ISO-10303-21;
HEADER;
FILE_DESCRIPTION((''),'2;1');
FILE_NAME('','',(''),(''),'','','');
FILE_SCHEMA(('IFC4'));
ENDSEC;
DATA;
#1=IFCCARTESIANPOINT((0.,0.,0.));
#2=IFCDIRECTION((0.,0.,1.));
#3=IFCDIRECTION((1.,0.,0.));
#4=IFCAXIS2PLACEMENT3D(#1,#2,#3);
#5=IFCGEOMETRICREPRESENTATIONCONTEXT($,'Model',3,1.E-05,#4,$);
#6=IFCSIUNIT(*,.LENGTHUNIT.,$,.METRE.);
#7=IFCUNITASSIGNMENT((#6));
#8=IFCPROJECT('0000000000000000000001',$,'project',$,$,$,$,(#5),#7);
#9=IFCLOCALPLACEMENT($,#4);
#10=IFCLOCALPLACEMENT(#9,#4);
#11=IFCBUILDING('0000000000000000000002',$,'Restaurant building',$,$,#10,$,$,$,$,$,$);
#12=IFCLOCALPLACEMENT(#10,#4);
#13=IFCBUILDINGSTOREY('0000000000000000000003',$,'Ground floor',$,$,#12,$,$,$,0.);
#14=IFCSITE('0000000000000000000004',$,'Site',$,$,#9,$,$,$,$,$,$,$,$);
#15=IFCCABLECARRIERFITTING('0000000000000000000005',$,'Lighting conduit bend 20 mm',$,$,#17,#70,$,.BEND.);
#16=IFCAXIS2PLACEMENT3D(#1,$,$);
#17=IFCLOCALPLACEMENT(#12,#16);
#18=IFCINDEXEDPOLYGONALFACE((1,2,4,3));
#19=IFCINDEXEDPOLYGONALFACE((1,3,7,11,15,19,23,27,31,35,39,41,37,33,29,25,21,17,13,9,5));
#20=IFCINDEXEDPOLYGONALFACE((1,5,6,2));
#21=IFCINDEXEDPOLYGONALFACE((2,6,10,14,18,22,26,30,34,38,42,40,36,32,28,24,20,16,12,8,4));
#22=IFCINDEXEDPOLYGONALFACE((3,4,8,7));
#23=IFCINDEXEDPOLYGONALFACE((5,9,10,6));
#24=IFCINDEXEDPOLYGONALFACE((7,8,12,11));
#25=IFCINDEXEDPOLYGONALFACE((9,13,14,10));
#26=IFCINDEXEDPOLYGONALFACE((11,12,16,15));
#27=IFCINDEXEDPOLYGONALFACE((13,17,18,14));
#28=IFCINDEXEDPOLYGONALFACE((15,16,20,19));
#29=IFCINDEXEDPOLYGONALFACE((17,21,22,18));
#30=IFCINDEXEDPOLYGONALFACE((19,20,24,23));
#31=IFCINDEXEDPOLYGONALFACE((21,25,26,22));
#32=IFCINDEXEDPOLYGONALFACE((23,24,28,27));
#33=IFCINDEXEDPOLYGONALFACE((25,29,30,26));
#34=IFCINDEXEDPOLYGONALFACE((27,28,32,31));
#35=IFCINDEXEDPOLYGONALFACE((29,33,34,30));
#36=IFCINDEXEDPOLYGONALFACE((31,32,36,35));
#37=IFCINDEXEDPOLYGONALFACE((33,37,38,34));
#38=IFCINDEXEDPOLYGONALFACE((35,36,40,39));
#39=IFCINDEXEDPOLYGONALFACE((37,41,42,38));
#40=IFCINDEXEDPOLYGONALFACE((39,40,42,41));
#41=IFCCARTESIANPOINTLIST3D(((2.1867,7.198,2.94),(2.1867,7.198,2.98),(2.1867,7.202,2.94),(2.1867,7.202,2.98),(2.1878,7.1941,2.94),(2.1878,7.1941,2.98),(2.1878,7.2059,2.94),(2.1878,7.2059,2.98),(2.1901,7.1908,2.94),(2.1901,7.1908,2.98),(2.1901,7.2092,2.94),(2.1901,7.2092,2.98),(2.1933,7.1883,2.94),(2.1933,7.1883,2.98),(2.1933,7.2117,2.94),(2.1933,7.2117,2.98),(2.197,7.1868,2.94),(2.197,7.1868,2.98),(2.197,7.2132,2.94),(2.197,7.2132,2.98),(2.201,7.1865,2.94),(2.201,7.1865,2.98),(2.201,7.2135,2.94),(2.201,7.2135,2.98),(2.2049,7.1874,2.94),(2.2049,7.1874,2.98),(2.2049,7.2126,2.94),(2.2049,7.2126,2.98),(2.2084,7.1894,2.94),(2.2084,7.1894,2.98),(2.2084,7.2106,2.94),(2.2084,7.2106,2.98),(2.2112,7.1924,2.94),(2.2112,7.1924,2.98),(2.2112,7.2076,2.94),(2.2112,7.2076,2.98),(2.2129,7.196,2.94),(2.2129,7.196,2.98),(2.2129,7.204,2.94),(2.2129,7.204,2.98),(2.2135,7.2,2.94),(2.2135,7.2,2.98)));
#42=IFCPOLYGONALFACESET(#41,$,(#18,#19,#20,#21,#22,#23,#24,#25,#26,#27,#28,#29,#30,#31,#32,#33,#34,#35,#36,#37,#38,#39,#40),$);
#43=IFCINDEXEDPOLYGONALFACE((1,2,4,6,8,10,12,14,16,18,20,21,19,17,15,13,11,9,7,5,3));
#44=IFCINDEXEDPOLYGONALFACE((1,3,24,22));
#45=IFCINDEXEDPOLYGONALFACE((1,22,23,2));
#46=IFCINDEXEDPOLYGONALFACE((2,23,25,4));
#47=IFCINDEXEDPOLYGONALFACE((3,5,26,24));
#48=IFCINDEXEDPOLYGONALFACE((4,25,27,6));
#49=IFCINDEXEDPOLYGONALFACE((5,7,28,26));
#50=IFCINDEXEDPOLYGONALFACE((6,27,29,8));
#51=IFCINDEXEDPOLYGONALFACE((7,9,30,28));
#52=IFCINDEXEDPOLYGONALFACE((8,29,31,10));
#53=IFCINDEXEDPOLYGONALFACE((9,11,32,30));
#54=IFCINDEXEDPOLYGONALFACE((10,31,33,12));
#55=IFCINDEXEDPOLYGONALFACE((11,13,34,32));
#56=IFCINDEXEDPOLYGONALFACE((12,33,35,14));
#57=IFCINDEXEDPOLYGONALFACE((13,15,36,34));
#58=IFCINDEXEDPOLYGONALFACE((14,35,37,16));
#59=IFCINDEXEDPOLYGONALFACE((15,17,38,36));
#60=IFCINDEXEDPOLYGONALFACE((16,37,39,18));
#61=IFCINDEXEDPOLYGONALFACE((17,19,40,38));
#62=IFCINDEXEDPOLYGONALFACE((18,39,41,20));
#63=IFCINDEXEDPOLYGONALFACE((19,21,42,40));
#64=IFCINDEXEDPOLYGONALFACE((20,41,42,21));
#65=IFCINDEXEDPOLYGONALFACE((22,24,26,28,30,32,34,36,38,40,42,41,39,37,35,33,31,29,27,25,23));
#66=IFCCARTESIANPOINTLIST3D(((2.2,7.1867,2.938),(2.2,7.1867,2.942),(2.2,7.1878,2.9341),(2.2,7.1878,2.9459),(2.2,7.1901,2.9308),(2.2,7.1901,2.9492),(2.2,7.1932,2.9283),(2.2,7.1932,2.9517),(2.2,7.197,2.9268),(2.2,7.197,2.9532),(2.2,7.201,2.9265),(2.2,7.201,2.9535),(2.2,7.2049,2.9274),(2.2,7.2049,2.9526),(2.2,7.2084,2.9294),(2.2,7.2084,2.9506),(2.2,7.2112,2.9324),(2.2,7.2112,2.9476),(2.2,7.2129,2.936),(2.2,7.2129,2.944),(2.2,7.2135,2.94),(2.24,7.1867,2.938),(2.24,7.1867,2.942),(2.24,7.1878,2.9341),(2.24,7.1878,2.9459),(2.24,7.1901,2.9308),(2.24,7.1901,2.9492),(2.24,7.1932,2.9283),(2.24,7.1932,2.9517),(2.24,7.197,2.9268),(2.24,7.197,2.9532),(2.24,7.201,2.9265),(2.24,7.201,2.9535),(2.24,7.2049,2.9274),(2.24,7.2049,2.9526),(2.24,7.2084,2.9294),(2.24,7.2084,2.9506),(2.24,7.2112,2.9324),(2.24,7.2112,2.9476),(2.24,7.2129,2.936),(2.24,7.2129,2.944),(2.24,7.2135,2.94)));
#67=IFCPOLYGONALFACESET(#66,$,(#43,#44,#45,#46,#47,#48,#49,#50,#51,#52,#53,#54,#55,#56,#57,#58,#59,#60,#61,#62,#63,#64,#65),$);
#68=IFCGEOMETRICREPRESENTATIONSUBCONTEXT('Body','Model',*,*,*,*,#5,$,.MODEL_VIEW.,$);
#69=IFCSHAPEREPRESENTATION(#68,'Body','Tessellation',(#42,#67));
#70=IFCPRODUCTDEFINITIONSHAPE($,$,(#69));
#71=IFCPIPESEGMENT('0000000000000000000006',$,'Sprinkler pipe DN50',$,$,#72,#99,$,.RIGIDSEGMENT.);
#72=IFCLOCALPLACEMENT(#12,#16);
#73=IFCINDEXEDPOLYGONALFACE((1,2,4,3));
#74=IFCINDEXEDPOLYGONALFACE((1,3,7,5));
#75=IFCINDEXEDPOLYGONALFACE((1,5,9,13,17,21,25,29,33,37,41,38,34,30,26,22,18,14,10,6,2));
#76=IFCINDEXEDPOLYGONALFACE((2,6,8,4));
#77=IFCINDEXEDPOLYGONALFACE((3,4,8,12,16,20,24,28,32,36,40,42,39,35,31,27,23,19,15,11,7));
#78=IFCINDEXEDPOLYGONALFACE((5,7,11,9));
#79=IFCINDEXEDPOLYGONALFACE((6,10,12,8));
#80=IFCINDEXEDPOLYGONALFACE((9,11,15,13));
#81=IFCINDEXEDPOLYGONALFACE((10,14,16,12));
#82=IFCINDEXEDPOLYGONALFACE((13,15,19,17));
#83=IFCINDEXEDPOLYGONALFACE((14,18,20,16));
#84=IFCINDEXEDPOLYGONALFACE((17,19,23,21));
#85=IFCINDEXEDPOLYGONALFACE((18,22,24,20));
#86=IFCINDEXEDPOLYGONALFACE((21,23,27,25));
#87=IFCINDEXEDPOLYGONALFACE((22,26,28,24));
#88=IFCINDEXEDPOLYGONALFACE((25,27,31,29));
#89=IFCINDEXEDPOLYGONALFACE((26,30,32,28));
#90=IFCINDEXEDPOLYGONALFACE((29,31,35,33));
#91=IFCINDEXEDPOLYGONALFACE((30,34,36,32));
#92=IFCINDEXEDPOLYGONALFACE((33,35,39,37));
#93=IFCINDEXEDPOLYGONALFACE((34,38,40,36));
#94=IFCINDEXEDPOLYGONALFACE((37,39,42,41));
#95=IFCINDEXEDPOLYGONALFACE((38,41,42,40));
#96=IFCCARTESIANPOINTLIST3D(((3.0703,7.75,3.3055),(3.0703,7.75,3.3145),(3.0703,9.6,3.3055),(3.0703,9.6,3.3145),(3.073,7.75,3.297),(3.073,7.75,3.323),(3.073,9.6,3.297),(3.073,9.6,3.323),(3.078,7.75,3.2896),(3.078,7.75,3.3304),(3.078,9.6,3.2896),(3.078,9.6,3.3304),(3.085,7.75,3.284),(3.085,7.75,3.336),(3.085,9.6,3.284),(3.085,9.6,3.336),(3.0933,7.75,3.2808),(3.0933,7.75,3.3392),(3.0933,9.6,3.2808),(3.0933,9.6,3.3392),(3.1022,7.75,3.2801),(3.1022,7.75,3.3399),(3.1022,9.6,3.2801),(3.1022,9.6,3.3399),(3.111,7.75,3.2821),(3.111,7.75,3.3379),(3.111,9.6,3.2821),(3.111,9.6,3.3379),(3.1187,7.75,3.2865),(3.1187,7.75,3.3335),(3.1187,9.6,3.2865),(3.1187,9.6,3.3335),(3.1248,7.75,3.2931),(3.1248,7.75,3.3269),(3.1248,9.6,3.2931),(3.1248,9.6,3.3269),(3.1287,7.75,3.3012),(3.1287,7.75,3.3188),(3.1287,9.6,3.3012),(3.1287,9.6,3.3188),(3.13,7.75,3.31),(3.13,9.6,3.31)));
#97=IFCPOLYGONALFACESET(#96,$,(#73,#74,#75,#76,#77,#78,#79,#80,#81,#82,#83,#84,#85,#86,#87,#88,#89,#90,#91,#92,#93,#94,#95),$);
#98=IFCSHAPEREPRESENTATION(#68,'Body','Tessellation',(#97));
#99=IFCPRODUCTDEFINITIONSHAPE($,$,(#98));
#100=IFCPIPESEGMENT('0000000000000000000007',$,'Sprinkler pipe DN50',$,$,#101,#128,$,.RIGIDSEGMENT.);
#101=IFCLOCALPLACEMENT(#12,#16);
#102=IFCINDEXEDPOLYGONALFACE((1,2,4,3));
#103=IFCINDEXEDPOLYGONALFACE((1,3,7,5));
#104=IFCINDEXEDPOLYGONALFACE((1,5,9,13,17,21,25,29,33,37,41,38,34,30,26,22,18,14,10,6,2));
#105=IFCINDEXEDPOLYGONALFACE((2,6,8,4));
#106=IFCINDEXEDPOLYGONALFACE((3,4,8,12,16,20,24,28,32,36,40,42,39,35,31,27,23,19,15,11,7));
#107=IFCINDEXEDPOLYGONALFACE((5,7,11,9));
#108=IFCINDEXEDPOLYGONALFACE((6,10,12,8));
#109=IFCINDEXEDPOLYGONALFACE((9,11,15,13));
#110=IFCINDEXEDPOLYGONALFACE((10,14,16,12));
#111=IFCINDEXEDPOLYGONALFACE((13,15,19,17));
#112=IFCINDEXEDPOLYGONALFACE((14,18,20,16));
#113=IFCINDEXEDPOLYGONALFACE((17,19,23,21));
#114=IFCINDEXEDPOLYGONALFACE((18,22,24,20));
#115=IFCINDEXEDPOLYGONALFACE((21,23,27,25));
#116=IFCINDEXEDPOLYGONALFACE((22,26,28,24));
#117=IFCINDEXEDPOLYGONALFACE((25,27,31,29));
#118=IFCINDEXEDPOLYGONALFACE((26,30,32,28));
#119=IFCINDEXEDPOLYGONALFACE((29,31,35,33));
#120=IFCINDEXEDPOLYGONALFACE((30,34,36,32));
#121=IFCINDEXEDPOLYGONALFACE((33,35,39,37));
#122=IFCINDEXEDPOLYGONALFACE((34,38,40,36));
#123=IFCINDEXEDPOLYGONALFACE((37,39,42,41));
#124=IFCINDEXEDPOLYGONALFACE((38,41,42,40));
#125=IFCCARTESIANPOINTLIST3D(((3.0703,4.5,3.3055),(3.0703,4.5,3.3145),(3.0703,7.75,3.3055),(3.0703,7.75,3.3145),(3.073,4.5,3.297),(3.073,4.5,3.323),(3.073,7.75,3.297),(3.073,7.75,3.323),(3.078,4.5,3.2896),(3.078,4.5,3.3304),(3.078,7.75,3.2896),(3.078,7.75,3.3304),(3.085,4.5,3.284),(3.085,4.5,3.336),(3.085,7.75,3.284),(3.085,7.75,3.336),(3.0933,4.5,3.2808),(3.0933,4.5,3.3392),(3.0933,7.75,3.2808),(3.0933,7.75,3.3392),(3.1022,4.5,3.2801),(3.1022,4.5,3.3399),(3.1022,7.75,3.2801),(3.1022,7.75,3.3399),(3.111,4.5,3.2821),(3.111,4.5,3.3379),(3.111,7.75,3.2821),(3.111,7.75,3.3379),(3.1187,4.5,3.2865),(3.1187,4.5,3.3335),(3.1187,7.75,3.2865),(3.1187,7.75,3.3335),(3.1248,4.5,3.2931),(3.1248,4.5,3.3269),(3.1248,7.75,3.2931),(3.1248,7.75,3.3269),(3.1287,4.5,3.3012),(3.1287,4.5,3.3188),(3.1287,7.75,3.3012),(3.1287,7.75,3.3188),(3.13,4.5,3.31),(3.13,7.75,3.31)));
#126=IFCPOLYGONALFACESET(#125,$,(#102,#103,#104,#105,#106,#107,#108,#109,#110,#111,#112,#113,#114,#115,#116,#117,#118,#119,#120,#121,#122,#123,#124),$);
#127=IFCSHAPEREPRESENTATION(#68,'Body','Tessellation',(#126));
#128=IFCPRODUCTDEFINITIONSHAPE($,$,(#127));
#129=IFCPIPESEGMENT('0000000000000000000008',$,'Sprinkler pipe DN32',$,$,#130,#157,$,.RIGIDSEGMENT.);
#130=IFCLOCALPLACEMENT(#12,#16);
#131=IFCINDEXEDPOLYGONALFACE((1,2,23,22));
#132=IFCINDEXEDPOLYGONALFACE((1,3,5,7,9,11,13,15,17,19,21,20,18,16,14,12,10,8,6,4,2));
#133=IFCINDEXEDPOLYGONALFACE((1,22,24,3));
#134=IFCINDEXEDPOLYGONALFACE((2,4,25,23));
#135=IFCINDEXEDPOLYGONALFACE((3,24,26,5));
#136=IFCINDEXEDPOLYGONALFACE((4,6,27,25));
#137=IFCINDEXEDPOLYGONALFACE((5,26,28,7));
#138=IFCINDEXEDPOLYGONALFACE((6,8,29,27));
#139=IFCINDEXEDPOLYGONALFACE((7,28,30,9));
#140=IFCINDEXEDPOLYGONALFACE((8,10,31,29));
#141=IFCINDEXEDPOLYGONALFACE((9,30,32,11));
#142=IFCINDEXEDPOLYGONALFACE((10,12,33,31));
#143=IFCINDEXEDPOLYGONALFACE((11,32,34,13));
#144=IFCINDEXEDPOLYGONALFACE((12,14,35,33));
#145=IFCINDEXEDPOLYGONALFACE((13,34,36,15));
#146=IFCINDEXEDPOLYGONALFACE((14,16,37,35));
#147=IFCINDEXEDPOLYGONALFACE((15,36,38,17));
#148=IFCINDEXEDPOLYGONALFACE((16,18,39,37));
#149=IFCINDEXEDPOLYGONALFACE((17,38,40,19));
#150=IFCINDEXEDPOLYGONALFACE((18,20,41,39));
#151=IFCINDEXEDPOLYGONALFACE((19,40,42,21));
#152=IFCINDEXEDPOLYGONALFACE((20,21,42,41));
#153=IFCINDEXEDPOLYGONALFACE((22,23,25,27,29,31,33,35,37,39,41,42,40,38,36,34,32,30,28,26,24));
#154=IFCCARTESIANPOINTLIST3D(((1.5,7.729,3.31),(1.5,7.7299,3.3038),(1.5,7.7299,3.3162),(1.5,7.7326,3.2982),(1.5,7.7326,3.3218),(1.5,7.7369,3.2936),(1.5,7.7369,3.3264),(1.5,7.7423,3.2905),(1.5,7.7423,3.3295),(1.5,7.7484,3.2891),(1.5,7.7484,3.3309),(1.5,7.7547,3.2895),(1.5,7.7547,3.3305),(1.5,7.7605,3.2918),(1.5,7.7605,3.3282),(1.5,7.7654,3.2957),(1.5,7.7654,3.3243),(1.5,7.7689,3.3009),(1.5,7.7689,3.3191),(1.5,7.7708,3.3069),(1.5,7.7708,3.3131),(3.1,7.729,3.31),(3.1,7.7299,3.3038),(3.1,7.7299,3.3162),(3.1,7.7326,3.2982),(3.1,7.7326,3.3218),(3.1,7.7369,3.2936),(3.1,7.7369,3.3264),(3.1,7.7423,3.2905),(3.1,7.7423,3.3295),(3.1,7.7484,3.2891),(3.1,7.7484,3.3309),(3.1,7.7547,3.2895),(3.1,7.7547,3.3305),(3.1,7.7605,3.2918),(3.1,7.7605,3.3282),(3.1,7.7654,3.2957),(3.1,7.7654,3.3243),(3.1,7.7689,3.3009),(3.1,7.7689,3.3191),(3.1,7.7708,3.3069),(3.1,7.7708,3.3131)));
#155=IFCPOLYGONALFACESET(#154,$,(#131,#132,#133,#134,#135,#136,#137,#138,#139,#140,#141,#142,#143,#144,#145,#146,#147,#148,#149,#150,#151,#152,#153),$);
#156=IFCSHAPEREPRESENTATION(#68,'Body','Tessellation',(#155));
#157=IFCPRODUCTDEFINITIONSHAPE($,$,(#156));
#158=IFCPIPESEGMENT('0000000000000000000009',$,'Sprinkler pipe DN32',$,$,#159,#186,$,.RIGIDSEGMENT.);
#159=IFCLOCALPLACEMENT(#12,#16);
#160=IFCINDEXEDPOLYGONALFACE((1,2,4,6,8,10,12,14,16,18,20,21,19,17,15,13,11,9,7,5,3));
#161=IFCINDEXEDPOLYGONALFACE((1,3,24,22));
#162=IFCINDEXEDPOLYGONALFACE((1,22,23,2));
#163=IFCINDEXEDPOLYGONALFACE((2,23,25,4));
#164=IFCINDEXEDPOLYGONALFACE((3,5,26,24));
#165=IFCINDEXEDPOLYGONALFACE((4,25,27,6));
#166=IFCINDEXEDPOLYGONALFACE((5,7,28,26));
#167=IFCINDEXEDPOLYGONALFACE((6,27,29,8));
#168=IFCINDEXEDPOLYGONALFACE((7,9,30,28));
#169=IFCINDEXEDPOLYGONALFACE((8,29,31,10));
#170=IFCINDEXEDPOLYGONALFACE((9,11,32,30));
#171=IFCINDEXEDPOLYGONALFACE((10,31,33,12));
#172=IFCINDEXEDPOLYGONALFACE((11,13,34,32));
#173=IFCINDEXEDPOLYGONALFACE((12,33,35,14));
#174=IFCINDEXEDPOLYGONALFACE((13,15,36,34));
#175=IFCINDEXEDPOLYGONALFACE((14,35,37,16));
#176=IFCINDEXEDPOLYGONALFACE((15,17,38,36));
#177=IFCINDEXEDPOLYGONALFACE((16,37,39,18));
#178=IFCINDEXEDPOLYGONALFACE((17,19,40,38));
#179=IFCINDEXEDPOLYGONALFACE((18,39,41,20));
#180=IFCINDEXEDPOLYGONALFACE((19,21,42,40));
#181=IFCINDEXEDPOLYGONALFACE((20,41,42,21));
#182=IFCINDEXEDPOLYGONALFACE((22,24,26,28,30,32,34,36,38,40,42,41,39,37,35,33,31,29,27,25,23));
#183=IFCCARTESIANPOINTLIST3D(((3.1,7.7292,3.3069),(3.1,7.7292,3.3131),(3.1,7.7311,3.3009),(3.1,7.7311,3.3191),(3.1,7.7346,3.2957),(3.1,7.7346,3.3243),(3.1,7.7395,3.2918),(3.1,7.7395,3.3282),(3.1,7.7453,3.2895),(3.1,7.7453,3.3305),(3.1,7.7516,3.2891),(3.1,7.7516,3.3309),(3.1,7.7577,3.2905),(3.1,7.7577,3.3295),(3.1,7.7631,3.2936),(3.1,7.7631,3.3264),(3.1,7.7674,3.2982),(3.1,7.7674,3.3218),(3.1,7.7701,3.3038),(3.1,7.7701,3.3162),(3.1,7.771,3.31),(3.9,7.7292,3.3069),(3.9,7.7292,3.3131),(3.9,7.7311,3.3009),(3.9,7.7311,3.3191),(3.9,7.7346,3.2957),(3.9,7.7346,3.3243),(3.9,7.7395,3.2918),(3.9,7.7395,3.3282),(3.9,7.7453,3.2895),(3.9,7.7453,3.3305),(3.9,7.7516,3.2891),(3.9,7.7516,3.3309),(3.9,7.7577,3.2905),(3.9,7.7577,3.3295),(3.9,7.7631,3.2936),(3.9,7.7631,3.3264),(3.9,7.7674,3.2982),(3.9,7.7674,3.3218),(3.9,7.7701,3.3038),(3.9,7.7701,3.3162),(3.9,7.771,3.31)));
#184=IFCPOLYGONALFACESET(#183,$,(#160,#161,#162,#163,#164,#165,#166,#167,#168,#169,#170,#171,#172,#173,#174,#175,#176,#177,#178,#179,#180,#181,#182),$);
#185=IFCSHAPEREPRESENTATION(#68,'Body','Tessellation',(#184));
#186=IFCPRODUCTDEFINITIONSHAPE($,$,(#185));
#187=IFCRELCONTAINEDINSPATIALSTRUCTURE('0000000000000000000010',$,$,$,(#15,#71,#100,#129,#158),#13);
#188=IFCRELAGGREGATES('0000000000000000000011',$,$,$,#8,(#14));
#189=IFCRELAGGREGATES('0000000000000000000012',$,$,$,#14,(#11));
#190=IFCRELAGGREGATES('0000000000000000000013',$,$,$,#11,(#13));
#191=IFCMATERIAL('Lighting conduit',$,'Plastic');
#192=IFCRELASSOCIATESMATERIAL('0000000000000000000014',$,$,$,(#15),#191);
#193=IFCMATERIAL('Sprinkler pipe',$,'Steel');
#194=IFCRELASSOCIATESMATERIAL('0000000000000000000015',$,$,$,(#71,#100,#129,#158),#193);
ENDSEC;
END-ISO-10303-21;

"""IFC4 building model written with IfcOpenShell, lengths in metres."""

from ifc_helpers import new_model, si_unit, frame, origin, origin_with_axes, origin_2d, place, context, subcontext, project, spatial, circle, extrude, material, element, save


model = new_model("IFC4")

# Units and contexts
model_context = context("Model", 3, precision=1e-05, world=origin_with_axes())
body_context = subcontext(model_context, "Body", "Model", "MODEL_VIEW")
ifc_project = project(units=[si_unit("LENGTHUNIT", "METRE")], contexts=[model_context])

# Site, building, storey
site_placement = place(None, origin_with_axes())
site = spatial("IfcSite", under=ifc_project, at=site_placement, Name="Site")
building_placement = place(site_placement, origin_with_axes())
building = spatial("IfcBuilding", under=site, at=building_placement, Name="Restaurant building")
storey_placement = place(building_placement, origin_with_axes())
storey = spatial("IfcBuildingStorey", under=building, at=storey_placement, Name="Ground floor", Elevation=0.0)

# Shared definitions
ifc_material_1 = material(Name="Lighting conduit", Category="Plastic")

# Cable carrier fitting
cable_carrier_fitting_1_placement = place(storey_placement, frame((2.2, 7.2, 2.94)))
element("IfcCableCarrierFitting", 1, at=cable_carrier_fitting_1_placement, inside=storey, material=ifc_material_1, Name="Lighting conduit bend 20 mm", PredefinedType="BEND", context=body_context, shape_type="SweptSolid", body=[
    extrude(circle(Radius=0.0135, at=origin_2d()), origin(), (0.0, 0.0, 1.0), 0.04),
    extrude(circle(Radius=0.0135, at=origin_2d()), frame((0.0, 0.0, 0.0), z_axis=(1.0, 0.0, 0.0), x_axis=(0.0, 1.0, 0.0)), (0.0, 0.0, 1.0), 0.04),
])

# Pipe segments
ifc_material_2 = material(Name="Sprinkler pipe", Category="Steel")
pipe_segment_1_placement = place(storey_placement, frame((3.1, 9.6, 3.31)))
element("IfcPipeSegment", 2, at=pipe_segment_1_placement, inside=storey, material=ifc_material_2, Name="Sprinkler pipe DN50", PredefinedType="RIGIDSEGMENT", context=body_context, shape_type="SweptSolid", body=[
    extrude(circle(Radius=0.03, at=origin_2d()), frame((0.0, 0.0, 0.0), z_axis=(0.0, -1.0, 0.0), x_axis=(1.0, 0.0, 0.0)), (0.0, 0.0, 1.0), 1.85),
])
pipe_segment_2_placement = place(storey_placement, frame((3.1, 7.75, 3.31)))
element("IfcPipeSegment", 3, at=pipe_segment_2_placement, inside=storey, material=ifc_material_2, Name="Sprinkler pipe DN50", PredefinedType="RIGIDSEGMENT", context=body_context, shape_type="SweptSolid", body=[
    extrude(circle(Radius=0.03, at=origin_2d()), frame((0.0, 0.0, 0.0), z_axis=(0.0, -1.0, 0.0), x_axis=(1.0, 0.0, 0.0)), (0.0, 0.0, 1.0), 3.25),
])
pipe_segment_3_placement = place(storey_placement, frame((3.1, 7.75, 3.31)))
element("IfcPipeSegment", 4, at=pipe_segment_3_placement, inside=storey, material=ifc_material_2, Name="Sprinkler pipe DN32", PredefinedType="RIGIDSEGMENT", context=body_context, shape_type="SweptSolid", body=[
    extrude(circle(Radius=0.021, at=origin_2d()), frame((0.0, 0.0, 0.0), z_axis=(-1.0, 0.0, 0.0), x_axis=(0.0, -1.0, 0.0)), (0.0, 0.0, 1.0), 1.6),
])
pipe_segment_4_placement = place(storey_placement, frame((3.1, 7.75, 3.31)))
element("IfcPipeSegment", 5, at=pipe_segment_4_placement, inside=storey, material=ifc_material_2, Name="Sprinkler pipe DN32", PredefinedType="RIGIDSEGMENT", context=body_context, shape_type="SweptSolid", body=[
    extrude(circle(Radius=0.021, at=origin_2d()), frame((0.0, 0.0, 0.0), z_axis=(1.0, 0.0, 0.0), x_axis=(0.0, 1.0, 0.0)), (0.0, 0.0, 1.0), 0.8),
])

save(model, "model.ifc")
